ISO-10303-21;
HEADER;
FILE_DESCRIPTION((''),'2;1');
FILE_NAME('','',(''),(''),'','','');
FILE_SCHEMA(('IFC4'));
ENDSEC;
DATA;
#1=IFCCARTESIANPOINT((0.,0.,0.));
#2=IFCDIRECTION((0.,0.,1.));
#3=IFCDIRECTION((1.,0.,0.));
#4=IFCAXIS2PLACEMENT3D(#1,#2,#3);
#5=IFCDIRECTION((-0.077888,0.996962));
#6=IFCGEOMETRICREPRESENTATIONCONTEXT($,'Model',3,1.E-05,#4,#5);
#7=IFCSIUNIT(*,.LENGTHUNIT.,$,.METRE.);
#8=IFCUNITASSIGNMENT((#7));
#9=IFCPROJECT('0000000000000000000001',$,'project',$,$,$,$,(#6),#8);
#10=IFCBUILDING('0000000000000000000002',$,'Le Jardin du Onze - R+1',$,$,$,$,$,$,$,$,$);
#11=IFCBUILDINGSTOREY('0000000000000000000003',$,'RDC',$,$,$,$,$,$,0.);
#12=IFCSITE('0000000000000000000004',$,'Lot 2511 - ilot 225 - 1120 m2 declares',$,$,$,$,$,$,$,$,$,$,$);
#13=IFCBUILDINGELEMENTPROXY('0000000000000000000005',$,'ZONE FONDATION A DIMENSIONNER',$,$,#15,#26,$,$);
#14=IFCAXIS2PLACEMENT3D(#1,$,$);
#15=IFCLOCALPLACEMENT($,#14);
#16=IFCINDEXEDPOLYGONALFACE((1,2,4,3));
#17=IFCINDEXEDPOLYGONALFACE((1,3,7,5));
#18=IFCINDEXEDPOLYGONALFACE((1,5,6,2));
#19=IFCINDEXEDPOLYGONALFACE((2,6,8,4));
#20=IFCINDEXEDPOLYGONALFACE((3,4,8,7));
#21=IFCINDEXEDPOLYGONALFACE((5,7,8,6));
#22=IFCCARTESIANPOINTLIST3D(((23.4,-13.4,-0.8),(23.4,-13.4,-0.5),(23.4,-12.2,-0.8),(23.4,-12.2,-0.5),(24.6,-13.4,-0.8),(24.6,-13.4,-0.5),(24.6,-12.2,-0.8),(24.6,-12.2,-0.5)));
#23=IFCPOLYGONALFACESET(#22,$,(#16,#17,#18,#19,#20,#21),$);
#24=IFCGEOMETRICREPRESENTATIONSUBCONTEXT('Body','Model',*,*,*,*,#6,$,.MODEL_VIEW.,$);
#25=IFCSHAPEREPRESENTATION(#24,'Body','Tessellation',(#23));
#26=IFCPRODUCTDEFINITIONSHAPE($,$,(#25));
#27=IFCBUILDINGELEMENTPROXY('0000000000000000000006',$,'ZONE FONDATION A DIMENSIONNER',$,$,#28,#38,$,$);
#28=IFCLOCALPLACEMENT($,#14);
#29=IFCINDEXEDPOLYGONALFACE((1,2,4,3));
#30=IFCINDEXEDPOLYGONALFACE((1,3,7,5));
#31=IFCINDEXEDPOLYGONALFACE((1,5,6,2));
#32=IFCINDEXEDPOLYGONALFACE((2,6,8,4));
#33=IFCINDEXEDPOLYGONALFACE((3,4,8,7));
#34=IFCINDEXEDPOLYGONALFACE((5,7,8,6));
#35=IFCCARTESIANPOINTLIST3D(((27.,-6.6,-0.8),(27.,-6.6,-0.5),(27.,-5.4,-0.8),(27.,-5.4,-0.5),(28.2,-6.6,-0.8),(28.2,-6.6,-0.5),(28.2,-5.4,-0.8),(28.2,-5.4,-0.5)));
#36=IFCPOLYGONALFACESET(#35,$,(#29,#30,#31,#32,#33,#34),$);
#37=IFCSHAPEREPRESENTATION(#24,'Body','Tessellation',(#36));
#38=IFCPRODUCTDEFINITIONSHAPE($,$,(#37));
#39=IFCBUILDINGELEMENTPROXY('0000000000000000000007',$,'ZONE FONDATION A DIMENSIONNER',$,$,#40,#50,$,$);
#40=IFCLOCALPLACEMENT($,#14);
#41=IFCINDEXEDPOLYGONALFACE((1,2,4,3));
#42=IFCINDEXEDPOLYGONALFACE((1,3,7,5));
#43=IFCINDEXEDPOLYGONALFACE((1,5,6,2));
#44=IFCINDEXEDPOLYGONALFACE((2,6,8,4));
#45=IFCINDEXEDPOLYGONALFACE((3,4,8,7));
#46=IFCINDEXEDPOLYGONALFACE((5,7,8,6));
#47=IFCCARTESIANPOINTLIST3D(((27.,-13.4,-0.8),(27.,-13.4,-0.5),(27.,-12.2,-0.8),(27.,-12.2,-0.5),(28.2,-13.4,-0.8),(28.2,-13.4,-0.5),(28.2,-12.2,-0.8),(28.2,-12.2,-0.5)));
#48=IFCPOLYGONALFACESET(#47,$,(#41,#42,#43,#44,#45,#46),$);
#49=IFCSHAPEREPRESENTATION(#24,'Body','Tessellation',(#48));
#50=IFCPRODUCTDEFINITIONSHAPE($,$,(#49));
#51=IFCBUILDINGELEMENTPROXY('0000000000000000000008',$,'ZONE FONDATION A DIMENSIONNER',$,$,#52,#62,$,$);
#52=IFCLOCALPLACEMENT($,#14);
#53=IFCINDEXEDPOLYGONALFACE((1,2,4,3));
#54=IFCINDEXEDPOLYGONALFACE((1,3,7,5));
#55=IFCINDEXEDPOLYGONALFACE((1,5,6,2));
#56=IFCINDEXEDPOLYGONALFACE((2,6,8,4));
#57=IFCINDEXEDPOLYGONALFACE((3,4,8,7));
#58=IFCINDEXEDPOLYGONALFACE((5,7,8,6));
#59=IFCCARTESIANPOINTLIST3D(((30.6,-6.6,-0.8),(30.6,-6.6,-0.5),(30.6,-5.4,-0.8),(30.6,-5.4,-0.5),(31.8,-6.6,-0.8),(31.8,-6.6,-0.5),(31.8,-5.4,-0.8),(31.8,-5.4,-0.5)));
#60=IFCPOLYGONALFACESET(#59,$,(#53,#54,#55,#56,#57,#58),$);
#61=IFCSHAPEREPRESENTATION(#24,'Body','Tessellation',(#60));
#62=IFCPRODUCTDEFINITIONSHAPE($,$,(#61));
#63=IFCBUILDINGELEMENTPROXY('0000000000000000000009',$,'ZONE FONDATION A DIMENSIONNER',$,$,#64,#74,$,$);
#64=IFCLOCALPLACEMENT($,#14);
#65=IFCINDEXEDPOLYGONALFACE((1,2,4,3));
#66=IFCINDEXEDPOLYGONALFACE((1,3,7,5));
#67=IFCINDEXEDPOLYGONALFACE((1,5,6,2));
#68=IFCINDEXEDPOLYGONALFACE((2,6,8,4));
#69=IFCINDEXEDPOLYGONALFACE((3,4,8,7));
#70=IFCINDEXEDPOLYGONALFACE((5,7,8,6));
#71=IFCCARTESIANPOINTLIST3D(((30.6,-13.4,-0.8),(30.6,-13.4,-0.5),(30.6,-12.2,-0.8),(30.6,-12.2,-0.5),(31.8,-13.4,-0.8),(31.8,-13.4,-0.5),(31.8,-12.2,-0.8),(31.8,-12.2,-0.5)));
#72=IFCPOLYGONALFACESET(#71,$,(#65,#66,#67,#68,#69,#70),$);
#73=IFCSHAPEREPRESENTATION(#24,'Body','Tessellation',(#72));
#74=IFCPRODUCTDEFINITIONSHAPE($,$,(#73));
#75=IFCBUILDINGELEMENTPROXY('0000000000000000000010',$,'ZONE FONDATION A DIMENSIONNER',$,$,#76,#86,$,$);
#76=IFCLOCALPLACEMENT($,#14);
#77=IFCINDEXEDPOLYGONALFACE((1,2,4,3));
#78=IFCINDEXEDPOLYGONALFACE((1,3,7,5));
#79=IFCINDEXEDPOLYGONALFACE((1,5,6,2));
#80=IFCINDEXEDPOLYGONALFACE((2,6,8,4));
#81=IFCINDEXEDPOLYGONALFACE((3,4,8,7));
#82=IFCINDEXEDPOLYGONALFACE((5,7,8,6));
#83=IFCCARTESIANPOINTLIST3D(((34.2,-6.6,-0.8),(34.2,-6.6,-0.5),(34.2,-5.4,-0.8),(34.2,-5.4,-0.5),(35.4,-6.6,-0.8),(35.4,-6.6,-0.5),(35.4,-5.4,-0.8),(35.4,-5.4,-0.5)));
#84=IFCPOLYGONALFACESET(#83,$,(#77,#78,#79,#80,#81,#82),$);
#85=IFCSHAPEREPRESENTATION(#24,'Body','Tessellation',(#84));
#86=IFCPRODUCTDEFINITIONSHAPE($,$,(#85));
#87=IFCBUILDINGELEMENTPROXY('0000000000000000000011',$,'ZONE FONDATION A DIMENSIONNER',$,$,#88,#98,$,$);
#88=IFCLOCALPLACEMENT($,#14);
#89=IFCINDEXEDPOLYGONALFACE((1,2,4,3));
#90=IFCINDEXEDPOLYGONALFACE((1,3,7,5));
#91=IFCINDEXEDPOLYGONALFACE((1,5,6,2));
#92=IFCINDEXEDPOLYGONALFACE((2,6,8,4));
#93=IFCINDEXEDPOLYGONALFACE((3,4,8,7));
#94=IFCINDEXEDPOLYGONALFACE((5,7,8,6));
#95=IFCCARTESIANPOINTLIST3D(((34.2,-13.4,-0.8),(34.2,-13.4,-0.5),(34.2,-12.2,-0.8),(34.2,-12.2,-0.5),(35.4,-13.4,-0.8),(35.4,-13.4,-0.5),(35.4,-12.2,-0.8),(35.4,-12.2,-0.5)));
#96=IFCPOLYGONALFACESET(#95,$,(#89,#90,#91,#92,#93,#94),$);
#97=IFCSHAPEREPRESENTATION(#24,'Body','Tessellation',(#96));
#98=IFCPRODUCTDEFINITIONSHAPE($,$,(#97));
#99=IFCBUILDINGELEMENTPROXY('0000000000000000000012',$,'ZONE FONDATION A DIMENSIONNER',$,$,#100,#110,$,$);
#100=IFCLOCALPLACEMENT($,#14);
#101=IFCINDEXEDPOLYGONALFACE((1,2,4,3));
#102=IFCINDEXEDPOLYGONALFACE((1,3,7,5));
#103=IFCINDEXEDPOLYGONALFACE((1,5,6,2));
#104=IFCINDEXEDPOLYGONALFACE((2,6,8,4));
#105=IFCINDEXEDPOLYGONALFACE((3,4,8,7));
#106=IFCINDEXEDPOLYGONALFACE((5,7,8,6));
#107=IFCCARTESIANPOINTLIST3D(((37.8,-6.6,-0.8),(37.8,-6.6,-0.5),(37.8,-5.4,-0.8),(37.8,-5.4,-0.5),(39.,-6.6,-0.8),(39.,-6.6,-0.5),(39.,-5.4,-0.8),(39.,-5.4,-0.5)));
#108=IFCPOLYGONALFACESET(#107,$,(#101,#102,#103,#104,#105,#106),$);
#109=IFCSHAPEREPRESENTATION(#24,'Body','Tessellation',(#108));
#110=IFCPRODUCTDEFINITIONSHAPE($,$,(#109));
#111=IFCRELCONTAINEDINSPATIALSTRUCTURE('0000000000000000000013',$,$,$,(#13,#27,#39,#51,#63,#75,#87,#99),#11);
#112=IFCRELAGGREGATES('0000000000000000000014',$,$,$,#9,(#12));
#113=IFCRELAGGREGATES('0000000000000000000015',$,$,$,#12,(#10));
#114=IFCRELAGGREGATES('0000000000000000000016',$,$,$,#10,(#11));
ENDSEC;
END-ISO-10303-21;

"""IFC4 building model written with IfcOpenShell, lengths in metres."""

from ifc_helpers import new_model, si_unit, direction, frame, origin_with_axes, place, context, subcontext, project, spatial, polyline, outline, extrude, element, save


model = new_model("IFC4")

# Units and contexts
model_context = context("Model", 3, precision=1e-05, world=origin_with_axes(), true_north=direction((-0.077888, 0.996962)))
body_context = subcontext(model_context, "Body", "Model", "MODEL_VIEW")
ifc_project = project(units=[si_unit("LENGTHUNIT", "METRE")], contexts=[model_context])

# Site, building, storey
site = spatial("IfcSite", under=ifc_project, Name="Lot 2511 - ilot 225 - 1120 m2 declares")
building = spatial("IfcBuilding", under=site, Name="Le Jardin du Onze - R+1")
storey = spatial("IfcBuildingStorey", under=building, Name="RDC", Elevation=0.0)

# Building element proxies
proxy_1_placement = place(None, origin_with_axes())
element("IfcBuildingElementProxy", 1, at=proxy_1_placement, inside=storey, Name="ZONE FONDATION A DIMENSIONNER", context=body_context, shape_type="SweptSolid", body=[
    extrude(outline(polyline([(24.6, -13.4), (24.6, -12.2), (23.4, -12.2), (23.4, -13.4), (24.6, -13.4)])), frame((0.0, 0.0, -0.8)), (0.0, 0.0, 1.0), 0.3),
])
proxy_2_placement = place(None, origin_with_axes())
element("IfcBuildingElementProxy", 2, at=proxy_2_placement, inside=storey, Name="ZONE FONDATION A DIMENSIONNER", context=body_context, shape_type="SweptSolid", body=[
    extrude(outline(polyline([(28.2, -6.6), (28.2, -5.4), (27.0, -5.4), (27.0, -6.6), (28.2, -6.6)])), frame((0.0, 0.0, -0.8)), (0.0, 0.0, 1.0), 0.3),
])
proxy_3_placement = place(None, origin_with_axes())
element("IfcBuildingElementProxy", 3, at=proxy_3_placement, inside=storey, Name="ZONE FONDATION A DIMENSIONNER", context=body_context, shape_type="SweptSolid", body=[
    extrude(outline(polyline([(28.2, -13.4), (28.2, -12.2), (27.0, -12.2), (27.0, -13.4), (28.2, -13.4)])), frame((0.0, 0.0, -0.8)), (0.0, 0.0, 1.0), 0.3),
])
proxy_4_placement = place(None, origin_with_axes())
element("IfcBuildingElementProxy", 4, at=proxy_4_placement, inside=storey, Name="ZONE FONDATION A DIMENSIONNER", context=body_context, shape_type="SweptSolid", body=[
    extrude(outline(polyline([(31.8, -6.6), (31.8, -5.4), (30.6, -5.4), (30.6, -6.6), (31.8, -6.6)])), frame((0.0, 0.0, -0.8)), (0.0, 0.0, 1.0), 0.3),
])
proxy_5_placement = place(None, origin_with_axes())
element("IfcBuildingElementProxy", 5, at=proxy_5_placement, inside=storey, Name="ZONE FONDATION A DIMENSIONNER", context=body_context, shape_type="SweptSolid", body=[
    extrude(outline(polyline([(31.8, -13.4), (31.8, -12.2), (30.6, -12.2), (30.6, -13.4), (31.8, -13.4)])), frame((0.0, 0.0, -0.8)), (0.0, 0.0, 1.0), 0.3),
])
proxy_6_placement = place(None, origin_with_axes())
element("IfcBuildingElementProxy", 6, at=proxy_6_placement, inside=storey, Name="ZONE FONDATION A DIMENSIONNER", context=body_context, shape_type="SweptSolid", body=[
    extrude(outline(polyline([(35.4, -6.6), (35.4, -5.4), (34.2, -5.4), (34.2, -6.6), (35.4, -6.6)])), frame((0.0, 0.0, -0.8)), (0.0, 0.0, 1.0), 0.3),
])
proxy_7_placement = place(None, origin_with_axes())
element("IfcBuildingElementProxy", 7, at=proxy_7_placement, inside=storey, Name="ZONE FONDATION A DIMENSIONNER", context=body_context, shape_type="SweptSolid", body=[
    extrude(outline(polyline([(35.4, -13.4), (35.4, -12.2), (34.2, -12.2), (34.2, -13.4), (35.4, -13.4)])), frame((0.0, 0.0, -0.8)), (0.0, 0.0, 1.0), 0.3),
])
proxy_8_placement = place(None, origin_with_axes())
element("IfcBuildingElementProxy", 8, at=proxy_8_placement, inside=storey, Name="ZONE FONDATION A DIMENSIONNER", context=body_context, shape_type="SweptSolid", body=[
    extrude(outline(polyline([(39.0, -6.6), (39.0, -5.4), (37.8, -5.4), (37.8, -6.6), (39.0, -6.6)])), frame((0.0, 0.0, -0.8)), (0.0, 0.0, 1.0), 0.3),
])

save(model, "model.ifc")
